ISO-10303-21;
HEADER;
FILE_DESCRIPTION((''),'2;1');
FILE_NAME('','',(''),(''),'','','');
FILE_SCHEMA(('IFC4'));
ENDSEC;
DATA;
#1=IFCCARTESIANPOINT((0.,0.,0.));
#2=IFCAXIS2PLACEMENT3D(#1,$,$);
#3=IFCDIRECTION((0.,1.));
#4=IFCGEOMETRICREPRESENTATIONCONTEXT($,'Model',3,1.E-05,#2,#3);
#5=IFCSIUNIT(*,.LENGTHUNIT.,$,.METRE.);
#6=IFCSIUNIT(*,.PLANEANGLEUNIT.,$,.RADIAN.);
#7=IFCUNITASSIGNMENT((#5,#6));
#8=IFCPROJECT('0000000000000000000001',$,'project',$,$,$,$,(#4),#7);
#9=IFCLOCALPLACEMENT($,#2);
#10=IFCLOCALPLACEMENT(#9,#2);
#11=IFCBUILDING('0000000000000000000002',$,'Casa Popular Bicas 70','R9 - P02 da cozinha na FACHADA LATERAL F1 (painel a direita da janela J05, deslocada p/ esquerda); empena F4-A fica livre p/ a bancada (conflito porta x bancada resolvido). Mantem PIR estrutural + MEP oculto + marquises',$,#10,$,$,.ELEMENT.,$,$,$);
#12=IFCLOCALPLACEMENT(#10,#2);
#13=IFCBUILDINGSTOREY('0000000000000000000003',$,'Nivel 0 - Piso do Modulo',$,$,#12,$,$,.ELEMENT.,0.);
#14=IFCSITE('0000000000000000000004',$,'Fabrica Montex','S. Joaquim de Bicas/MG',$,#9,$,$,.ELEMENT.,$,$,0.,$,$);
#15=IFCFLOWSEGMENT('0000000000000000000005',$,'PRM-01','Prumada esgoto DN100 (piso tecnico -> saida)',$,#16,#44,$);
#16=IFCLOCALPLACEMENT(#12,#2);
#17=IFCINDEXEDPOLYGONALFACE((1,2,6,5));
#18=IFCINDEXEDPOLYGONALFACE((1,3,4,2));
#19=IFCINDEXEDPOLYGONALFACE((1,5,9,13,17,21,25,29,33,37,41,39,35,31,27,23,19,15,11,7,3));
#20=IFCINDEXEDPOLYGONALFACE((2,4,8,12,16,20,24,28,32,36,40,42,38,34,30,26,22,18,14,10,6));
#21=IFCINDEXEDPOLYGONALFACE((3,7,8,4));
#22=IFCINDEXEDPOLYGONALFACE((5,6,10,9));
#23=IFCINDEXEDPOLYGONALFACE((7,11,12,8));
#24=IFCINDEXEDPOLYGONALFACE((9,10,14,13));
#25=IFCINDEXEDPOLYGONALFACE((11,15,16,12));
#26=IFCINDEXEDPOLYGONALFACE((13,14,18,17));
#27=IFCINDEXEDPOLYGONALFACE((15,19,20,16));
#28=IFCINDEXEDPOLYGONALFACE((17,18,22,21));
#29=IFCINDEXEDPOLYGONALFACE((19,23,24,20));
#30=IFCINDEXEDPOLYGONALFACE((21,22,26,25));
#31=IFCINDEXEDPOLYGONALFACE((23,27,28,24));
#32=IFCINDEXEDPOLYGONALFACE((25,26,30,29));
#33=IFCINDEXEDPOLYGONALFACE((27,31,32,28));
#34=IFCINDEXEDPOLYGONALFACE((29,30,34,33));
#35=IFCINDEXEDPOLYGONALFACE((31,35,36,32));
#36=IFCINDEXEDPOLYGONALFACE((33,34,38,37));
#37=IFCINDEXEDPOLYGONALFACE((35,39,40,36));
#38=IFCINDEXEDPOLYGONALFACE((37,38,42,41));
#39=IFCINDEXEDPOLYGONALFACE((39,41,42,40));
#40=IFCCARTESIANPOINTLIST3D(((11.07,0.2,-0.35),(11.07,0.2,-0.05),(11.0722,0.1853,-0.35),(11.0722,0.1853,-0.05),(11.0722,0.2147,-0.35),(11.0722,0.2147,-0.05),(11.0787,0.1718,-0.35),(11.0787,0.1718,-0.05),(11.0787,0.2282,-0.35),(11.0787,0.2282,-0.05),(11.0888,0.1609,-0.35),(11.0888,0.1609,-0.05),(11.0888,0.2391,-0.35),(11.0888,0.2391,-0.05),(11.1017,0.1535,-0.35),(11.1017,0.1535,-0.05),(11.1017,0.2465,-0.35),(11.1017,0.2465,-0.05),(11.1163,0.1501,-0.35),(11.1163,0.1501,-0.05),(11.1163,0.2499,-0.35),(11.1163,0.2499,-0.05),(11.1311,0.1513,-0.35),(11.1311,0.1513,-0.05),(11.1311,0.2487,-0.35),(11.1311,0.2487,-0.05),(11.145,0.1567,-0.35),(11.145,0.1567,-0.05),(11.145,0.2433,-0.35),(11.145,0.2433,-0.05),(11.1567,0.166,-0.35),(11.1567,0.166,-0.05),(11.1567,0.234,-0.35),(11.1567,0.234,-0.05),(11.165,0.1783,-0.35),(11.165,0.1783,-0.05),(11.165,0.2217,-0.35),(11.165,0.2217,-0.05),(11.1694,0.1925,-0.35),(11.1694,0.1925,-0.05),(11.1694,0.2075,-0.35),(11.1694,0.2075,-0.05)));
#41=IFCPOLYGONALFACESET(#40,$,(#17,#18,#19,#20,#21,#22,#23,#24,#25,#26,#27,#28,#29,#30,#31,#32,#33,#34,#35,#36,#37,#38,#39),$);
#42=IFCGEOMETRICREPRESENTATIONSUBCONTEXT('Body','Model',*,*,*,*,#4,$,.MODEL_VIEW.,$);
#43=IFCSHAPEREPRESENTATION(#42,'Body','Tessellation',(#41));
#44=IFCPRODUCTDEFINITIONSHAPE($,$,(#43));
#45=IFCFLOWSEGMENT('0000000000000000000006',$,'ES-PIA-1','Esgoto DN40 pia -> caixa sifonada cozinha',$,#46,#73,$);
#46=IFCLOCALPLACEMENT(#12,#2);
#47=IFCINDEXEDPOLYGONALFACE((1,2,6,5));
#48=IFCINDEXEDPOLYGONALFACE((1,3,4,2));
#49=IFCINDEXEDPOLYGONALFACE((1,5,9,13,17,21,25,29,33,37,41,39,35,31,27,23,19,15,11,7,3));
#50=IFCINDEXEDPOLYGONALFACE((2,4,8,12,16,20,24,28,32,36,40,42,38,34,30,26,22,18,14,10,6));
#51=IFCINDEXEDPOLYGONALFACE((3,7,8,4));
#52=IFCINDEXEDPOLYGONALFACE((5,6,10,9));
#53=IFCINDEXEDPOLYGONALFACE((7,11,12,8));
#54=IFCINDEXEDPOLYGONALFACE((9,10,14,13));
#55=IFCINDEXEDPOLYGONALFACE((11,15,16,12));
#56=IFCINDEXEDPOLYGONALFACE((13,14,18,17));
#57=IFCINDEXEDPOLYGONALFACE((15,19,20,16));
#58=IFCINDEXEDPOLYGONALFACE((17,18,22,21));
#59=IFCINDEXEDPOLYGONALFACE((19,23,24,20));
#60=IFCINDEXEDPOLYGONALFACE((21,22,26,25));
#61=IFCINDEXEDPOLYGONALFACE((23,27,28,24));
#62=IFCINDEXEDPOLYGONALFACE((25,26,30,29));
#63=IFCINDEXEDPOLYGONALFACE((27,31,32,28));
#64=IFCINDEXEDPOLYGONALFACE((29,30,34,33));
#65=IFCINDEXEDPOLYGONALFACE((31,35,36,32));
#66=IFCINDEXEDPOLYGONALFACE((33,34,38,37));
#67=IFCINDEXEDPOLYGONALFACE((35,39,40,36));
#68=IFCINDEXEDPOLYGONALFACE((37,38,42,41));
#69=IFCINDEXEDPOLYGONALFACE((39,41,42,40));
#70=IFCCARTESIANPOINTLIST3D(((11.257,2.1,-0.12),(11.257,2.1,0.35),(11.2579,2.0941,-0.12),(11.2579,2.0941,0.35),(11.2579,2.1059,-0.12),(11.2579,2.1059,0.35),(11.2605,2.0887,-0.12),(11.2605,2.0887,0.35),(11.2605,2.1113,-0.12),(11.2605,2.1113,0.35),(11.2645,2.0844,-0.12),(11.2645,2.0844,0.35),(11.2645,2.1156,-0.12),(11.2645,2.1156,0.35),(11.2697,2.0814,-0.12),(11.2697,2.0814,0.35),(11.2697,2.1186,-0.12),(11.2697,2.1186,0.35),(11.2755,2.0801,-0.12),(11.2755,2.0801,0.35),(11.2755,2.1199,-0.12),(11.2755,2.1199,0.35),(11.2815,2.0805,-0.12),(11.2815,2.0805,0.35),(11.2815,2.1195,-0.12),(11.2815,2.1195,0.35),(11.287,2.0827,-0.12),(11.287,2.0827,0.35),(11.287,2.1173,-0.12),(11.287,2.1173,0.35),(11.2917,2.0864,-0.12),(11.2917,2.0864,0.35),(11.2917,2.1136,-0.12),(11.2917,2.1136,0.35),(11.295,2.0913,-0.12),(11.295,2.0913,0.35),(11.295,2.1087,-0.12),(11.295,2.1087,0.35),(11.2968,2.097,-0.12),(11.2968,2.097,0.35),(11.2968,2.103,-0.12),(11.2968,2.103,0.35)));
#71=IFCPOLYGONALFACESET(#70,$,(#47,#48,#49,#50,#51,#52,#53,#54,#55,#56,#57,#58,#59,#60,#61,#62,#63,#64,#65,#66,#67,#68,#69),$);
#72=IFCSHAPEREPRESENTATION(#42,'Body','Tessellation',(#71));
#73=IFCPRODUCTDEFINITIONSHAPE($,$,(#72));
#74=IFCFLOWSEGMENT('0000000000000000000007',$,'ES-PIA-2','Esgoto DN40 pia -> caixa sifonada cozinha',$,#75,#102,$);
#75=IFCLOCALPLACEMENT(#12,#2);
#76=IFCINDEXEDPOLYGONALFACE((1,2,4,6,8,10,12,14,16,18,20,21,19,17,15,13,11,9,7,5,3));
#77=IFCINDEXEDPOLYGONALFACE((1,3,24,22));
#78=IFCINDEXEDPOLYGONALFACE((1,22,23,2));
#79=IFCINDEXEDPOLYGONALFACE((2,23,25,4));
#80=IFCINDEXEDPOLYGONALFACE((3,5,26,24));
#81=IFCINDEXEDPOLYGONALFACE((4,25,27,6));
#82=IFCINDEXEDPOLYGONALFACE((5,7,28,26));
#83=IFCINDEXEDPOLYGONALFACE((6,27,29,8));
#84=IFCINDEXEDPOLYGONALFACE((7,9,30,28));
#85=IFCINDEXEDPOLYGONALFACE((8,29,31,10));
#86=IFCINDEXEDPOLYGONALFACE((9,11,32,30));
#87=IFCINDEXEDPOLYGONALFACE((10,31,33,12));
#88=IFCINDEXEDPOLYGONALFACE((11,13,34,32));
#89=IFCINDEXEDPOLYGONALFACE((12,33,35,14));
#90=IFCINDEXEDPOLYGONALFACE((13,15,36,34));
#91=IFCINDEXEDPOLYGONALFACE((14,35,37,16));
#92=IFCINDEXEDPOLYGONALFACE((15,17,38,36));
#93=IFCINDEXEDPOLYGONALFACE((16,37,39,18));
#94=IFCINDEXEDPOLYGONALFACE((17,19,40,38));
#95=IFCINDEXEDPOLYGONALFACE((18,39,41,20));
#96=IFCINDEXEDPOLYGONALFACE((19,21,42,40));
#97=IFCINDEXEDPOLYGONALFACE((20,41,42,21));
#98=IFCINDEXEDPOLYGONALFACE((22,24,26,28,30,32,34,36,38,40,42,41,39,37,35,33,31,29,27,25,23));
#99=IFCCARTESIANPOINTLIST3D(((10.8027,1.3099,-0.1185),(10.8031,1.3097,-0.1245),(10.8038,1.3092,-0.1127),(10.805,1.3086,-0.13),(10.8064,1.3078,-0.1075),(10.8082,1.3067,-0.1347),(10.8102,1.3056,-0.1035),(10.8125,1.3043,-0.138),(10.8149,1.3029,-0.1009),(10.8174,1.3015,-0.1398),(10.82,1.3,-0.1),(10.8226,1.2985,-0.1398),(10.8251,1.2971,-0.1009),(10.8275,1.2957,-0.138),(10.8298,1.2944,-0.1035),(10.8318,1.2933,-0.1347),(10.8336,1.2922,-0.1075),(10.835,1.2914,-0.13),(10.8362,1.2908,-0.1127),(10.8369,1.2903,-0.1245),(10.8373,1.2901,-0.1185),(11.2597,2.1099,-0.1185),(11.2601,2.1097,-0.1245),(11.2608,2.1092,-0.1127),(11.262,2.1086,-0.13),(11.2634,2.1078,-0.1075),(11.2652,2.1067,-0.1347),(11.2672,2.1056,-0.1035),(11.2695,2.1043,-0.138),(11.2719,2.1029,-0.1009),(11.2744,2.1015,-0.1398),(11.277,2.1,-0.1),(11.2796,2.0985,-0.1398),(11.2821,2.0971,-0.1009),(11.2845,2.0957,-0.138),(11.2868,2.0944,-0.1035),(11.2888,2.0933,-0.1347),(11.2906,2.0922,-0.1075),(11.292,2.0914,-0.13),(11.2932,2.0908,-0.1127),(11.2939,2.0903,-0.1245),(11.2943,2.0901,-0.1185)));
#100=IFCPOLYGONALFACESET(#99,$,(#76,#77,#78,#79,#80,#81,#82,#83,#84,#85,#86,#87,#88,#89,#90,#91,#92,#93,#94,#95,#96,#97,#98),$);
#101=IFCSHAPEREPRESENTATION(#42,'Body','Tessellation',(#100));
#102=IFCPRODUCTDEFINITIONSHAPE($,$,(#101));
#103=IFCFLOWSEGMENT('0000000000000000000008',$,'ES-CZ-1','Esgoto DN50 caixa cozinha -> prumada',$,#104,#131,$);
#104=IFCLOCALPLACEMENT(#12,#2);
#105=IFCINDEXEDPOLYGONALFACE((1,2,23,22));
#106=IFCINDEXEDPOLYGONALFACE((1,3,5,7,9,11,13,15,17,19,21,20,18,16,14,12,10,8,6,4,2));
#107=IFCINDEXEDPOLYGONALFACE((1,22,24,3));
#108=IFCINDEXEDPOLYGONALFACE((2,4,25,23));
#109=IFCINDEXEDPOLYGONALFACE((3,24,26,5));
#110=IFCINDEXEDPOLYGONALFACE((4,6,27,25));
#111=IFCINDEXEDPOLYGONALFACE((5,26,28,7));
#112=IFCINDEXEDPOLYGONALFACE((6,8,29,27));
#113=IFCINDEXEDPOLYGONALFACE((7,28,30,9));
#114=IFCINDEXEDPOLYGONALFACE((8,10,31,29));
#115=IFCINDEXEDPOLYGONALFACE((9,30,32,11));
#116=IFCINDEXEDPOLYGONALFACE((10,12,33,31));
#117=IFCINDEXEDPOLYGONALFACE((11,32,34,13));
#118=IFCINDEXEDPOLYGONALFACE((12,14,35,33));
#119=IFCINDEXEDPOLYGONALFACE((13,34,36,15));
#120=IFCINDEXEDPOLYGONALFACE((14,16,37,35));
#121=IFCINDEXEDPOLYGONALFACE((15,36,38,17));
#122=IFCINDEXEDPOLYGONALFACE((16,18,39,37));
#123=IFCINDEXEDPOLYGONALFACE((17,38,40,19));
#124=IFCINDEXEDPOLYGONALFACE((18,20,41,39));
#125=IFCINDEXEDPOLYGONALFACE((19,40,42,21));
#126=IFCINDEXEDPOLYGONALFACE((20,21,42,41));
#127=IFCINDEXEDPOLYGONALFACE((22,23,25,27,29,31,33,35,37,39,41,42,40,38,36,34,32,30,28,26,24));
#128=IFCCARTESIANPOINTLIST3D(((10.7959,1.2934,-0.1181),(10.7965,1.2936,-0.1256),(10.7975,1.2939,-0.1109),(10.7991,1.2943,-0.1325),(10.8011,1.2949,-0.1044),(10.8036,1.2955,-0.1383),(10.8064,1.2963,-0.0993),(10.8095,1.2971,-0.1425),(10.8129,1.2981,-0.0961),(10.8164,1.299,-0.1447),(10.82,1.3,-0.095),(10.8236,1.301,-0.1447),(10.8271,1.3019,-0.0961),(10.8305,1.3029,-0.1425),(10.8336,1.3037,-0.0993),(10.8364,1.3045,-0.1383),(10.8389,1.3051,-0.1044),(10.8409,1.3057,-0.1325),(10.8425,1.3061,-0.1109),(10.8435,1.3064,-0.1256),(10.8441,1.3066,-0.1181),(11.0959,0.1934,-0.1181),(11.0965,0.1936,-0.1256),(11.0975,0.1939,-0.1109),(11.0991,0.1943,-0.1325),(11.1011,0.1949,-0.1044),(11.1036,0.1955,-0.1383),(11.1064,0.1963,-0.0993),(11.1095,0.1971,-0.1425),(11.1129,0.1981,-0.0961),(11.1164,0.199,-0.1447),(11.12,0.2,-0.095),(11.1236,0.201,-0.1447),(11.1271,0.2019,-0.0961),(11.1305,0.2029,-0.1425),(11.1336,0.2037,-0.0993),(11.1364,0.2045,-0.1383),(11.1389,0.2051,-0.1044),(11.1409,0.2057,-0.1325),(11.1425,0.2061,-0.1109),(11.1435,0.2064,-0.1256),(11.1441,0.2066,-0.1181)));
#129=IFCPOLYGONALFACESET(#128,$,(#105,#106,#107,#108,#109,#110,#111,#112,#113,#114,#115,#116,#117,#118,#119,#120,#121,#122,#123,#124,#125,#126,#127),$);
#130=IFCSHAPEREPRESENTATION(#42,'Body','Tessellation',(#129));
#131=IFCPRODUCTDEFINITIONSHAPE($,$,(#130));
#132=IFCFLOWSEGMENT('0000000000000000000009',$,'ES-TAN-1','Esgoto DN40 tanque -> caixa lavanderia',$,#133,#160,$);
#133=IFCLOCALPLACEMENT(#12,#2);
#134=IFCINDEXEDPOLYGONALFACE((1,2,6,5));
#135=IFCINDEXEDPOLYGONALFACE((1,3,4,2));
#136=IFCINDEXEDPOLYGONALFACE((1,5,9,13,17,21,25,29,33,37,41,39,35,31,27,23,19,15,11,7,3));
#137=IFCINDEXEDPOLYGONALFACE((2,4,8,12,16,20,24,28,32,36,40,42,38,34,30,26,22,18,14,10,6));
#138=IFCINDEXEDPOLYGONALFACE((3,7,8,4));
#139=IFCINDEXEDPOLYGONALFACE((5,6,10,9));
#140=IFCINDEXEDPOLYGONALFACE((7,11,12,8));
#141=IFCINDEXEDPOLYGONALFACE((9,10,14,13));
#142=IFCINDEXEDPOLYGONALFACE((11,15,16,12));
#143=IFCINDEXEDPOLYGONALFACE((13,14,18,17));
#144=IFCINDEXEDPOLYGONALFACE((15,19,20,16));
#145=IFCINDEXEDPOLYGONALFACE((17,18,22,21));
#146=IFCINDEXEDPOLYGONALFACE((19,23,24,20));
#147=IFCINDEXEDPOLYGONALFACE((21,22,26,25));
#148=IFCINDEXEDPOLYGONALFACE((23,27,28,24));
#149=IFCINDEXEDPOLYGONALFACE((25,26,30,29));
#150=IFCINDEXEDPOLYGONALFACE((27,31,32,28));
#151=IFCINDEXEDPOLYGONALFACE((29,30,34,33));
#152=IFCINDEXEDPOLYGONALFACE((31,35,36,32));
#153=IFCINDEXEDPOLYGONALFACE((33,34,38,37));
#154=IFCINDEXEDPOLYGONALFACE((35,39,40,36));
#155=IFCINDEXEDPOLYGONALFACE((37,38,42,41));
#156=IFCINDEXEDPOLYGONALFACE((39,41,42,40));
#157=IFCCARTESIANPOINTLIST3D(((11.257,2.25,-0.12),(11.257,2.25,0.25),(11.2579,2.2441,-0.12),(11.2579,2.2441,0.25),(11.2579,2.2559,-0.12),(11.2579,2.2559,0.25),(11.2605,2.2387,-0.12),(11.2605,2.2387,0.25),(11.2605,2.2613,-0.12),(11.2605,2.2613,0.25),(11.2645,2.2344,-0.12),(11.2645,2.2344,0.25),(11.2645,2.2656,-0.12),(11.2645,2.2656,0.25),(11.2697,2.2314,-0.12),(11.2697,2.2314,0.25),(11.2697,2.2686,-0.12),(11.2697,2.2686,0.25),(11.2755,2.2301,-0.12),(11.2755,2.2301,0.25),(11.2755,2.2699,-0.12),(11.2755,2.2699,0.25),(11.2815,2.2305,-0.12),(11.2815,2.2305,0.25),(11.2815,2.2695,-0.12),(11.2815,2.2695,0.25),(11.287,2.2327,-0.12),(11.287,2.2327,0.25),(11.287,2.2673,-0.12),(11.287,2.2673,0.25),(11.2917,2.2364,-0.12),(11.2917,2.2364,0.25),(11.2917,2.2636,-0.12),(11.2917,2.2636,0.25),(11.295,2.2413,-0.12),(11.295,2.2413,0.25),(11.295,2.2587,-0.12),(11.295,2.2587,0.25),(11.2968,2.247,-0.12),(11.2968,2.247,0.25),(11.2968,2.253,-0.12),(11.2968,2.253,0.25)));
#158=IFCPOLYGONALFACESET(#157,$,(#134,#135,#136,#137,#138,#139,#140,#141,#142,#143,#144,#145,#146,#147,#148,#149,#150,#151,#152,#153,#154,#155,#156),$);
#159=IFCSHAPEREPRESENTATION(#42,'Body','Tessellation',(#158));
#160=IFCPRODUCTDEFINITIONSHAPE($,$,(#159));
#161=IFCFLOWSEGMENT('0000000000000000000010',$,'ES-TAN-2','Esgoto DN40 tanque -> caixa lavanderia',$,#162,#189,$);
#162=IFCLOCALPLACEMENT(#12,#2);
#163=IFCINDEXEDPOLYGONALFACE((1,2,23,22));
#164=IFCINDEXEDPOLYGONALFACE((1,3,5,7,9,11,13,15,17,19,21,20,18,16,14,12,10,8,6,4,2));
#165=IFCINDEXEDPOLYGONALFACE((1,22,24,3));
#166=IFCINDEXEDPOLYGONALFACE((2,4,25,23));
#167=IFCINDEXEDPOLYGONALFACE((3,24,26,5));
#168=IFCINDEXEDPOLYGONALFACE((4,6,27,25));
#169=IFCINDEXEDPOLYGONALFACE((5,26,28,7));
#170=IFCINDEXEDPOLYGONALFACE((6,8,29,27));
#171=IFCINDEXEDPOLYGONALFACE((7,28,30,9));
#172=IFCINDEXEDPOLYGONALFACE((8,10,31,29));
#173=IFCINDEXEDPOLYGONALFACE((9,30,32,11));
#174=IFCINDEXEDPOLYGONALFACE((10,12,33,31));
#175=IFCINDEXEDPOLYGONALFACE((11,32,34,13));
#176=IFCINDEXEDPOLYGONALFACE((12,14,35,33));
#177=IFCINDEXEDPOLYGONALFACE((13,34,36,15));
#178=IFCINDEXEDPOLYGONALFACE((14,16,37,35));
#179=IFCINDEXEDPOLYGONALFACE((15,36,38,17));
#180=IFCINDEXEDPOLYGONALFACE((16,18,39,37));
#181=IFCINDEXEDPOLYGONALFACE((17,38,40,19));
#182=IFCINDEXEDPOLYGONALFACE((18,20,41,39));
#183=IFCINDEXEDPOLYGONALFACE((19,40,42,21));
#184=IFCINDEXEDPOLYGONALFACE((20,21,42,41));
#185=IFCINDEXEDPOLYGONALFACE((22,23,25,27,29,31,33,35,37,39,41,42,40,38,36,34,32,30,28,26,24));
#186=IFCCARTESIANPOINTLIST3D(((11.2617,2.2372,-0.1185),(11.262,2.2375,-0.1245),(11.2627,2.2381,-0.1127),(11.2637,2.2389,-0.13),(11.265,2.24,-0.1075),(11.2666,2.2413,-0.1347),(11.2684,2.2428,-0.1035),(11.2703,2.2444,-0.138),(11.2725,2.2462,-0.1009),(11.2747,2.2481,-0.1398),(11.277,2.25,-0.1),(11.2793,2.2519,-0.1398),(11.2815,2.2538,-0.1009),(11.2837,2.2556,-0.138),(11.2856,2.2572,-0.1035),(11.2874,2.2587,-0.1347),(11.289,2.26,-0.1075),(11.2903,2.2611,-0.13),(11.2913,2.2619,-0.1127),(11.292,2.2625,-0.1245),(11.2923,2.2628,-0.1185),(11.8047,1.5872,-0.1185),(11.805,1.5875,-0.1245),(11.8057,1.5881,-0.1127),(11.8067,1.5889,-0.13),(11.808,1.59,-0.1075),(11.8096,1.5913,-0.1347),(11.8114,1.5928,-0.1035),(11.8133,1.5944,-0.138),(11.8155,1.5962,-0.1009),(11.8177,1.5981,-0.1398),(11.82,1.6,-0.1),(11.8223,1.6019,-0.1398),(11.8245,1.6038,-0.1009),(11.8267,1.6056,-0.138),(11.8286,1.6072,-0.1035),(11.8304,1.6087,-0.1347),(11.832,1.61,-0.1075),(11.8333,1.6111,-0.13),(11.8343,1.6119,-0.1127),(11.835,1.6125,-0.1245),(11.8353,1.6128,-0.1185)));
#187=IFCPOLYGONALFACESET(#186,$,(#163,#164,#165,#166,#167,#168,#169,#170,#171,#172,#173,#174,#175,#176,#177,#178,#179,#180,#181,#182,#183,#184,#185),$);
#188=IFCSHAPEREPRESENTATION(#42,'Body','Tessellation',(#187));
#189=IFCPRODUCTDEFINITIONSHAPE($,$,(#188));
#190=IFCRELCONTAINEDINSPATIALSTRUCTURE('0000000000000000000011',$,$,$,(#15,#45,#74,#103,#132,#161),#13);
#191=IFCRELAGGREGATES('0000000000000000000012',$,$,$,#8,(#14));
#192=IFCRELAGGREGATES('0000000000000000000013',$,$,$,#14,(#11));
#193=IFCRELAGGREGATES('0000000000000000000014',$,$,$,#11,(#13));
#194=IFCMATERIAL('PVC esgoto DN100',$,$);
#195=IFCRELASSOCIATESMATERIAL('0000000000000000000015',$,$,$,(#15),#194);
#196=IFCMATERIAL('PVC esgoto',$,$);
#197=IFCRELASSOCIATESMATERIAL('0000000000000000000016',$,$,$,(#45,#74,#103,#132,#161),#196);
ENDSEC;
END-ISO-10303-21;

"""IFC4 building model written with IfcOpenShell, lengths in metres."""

from ifc_helpers import new_model, si_unit, direction, frame, origin, origin_2d, place, context, subcontext, project, spatial, circle, extrude, material, element, save


model = new_model("IFC4")

# Units and contexts
model_context = context("Model", 3, precision=1e-05, world=origin(), true_north=direction((0.0, 1.0)))
body_context = subcontext(model_context, "Body", "Model", "MODEL_VIEW")
ifc_project = project(units=[si_unit("LENGTHUNIT", "METRE"), si_unit("PLANEANGLEUNIT", "RADIAN")], contexts=[model_context])

# Site, building, storey
site_placement = place(None, origin())
site = spatial("IfcSite", under=ifc_project, at=site_placement, Name="Fabrica Montex", Description="S. Joaquim de Bicas/MG", CompositionType="ELEMENT", RefElevation=0.0)
building_placement = place(site_placement, origin())
building = spatial("IfcBuilding", under=site, at=building_placement, Name="Casa Popular Bicas 70", Description="R9 - P02 da cozinha na FACHADA LATERAL F1 (painel a direita da janela J05, deslocada p/ esquerda); empena F4-A fica livre p/ a bancada (conflito porta x bancada resolvido). Mantem PIR estrutural + MEP oculto + marquises", CompositionType="ELEMENT")
storey_placement = place(building_placement, origin())
storey = spatial("IfcBuildingStorey", under=building, at=storey_placement, Name="Nivel 0 - Piso do Modulo", CompositionType="ELEMENT", Elevation=0.0)

# Flow segments
ifc_material_1 = material(Name="PVC esgoto DN100")
flow_segment_1_placement = place(None, frame((11.12, 0.2, -0.35), z_axis=(0.0, 0.0, 1.0), x_axis=(-1.0, 0.0, 0.0)))
element("IfcFlowSegment", 1, at=flow_segment_1_placement, inside=storey, material=ifc_material_1, Name="PRM-01", Description="Prumada esgoto DN100 (piso tecnico -> saida)", context=body_context, shape_type="SweptSolid", body=[
    extrude(circle(Radius=0.05, at=origin_2d()), origin(), (0.0, 0.0, 1.0), 0.3),
])
ifc_material_2 = material(Name="PVC esgoto")
flow_segment_2_placement = place(None, frame((11.277, 2.1, 0.35), z_axis=(0.0, 0.0, -1.0), x_axis=(-1.0, 0.0, 0.0)))
element("IfcFlowSegment", 2, at=flow_segment_2_placement, inside=storey, material=ifc_material_2, Name="ES-PIA-1", Description="Esgoto DN40 pia -> caixa sifonada cozinha", context=body_context, shape_type="SweptSolid", body=[
    extrude(circle(Radius=0.02, at=origin_2d()), origin(), (0.0, 0.0, 1.0), 0.47),
])
flow_segment_3_placement = place(None, frame((11.277, 2.1, -0.12), z_axis=(-0.496022, -0.86831, 0.0), x_axis=(0.0, 0.0, 1.0)))
element("IfcFlowSegment", 3, at=flow_segment_3_placement, inside=storey, material=ifc_material_2, Name="ES-PIA-2", Description="Esgoto DN40 pia -> caixa sifonada cozinha", context=body_context, shape_type="SweptSolid", body=[
    extrude(circle(Radius=0.02, at=origin_2d()), origin(), (0.0, 0.0, 1.0), 0.9213),
])
flow_segment_4_placement = place(None, frame((10.82, 1.3, -0.12), z_axis=(0.263117, -0.964764, 0.0), x_axis=(0.0, 0.0, 1.0)))
element("IfcFlowSegment", 4, at=flow_segment_4_placement, inside=storey, material=ifc_material_2, Name="ES-CZ-1", Description="Esgoto DN50 caixa cozinha -> prumada", context=body_context, shape_type="SweptSolid", body=[
    extrude(circle(Radius=0.025, at=origin_2d()), origin(), (0.0, 0.0, 1.0), 1.1402),
])
flow_segment_5_placement = place(None, frame((11.277, 2.25, 0.25), z_axis=(0.0, 0.0, -1.0), x_axis=(-1.0, 0.0, 0.0)))
element("IfcFlowSegment", 5, at=flow_segment_5_placement, inside=storey, material=ifc_material_2, Name="ES-TAN-1", Description="Esgoto DN40 tanque -> caixa lavanderia", context=body_context, shape_type="SweptSolid", body=[
    extrude(circle(Radius=0.02, at=origin_2d()), origin(), (0.0, 0.0, 1.0), 0.37),
])
flow_segment_6_placement = place(None, frame((11.277, 2.25, -0.12), z_axis=(0.641113, -0.767446, 0.0), x_axis=(0.0, 0.0, 1.0)))
element("IfcFlowSegment", 6, at=flow_segment_6_placement, inside=storey, material=ifc_material_2, Name="ES-TAN-2", Description="Esgoto DN40 tanque -> caixa lavanderia", context=body_context, shape_type="SweptSolid", body=[
    extrude(circle(Radius=0.02, at=origin_2d()), origin(), (0.0, 0.0, 1.0), 0.847),
])

save(model, "model.ifc")
